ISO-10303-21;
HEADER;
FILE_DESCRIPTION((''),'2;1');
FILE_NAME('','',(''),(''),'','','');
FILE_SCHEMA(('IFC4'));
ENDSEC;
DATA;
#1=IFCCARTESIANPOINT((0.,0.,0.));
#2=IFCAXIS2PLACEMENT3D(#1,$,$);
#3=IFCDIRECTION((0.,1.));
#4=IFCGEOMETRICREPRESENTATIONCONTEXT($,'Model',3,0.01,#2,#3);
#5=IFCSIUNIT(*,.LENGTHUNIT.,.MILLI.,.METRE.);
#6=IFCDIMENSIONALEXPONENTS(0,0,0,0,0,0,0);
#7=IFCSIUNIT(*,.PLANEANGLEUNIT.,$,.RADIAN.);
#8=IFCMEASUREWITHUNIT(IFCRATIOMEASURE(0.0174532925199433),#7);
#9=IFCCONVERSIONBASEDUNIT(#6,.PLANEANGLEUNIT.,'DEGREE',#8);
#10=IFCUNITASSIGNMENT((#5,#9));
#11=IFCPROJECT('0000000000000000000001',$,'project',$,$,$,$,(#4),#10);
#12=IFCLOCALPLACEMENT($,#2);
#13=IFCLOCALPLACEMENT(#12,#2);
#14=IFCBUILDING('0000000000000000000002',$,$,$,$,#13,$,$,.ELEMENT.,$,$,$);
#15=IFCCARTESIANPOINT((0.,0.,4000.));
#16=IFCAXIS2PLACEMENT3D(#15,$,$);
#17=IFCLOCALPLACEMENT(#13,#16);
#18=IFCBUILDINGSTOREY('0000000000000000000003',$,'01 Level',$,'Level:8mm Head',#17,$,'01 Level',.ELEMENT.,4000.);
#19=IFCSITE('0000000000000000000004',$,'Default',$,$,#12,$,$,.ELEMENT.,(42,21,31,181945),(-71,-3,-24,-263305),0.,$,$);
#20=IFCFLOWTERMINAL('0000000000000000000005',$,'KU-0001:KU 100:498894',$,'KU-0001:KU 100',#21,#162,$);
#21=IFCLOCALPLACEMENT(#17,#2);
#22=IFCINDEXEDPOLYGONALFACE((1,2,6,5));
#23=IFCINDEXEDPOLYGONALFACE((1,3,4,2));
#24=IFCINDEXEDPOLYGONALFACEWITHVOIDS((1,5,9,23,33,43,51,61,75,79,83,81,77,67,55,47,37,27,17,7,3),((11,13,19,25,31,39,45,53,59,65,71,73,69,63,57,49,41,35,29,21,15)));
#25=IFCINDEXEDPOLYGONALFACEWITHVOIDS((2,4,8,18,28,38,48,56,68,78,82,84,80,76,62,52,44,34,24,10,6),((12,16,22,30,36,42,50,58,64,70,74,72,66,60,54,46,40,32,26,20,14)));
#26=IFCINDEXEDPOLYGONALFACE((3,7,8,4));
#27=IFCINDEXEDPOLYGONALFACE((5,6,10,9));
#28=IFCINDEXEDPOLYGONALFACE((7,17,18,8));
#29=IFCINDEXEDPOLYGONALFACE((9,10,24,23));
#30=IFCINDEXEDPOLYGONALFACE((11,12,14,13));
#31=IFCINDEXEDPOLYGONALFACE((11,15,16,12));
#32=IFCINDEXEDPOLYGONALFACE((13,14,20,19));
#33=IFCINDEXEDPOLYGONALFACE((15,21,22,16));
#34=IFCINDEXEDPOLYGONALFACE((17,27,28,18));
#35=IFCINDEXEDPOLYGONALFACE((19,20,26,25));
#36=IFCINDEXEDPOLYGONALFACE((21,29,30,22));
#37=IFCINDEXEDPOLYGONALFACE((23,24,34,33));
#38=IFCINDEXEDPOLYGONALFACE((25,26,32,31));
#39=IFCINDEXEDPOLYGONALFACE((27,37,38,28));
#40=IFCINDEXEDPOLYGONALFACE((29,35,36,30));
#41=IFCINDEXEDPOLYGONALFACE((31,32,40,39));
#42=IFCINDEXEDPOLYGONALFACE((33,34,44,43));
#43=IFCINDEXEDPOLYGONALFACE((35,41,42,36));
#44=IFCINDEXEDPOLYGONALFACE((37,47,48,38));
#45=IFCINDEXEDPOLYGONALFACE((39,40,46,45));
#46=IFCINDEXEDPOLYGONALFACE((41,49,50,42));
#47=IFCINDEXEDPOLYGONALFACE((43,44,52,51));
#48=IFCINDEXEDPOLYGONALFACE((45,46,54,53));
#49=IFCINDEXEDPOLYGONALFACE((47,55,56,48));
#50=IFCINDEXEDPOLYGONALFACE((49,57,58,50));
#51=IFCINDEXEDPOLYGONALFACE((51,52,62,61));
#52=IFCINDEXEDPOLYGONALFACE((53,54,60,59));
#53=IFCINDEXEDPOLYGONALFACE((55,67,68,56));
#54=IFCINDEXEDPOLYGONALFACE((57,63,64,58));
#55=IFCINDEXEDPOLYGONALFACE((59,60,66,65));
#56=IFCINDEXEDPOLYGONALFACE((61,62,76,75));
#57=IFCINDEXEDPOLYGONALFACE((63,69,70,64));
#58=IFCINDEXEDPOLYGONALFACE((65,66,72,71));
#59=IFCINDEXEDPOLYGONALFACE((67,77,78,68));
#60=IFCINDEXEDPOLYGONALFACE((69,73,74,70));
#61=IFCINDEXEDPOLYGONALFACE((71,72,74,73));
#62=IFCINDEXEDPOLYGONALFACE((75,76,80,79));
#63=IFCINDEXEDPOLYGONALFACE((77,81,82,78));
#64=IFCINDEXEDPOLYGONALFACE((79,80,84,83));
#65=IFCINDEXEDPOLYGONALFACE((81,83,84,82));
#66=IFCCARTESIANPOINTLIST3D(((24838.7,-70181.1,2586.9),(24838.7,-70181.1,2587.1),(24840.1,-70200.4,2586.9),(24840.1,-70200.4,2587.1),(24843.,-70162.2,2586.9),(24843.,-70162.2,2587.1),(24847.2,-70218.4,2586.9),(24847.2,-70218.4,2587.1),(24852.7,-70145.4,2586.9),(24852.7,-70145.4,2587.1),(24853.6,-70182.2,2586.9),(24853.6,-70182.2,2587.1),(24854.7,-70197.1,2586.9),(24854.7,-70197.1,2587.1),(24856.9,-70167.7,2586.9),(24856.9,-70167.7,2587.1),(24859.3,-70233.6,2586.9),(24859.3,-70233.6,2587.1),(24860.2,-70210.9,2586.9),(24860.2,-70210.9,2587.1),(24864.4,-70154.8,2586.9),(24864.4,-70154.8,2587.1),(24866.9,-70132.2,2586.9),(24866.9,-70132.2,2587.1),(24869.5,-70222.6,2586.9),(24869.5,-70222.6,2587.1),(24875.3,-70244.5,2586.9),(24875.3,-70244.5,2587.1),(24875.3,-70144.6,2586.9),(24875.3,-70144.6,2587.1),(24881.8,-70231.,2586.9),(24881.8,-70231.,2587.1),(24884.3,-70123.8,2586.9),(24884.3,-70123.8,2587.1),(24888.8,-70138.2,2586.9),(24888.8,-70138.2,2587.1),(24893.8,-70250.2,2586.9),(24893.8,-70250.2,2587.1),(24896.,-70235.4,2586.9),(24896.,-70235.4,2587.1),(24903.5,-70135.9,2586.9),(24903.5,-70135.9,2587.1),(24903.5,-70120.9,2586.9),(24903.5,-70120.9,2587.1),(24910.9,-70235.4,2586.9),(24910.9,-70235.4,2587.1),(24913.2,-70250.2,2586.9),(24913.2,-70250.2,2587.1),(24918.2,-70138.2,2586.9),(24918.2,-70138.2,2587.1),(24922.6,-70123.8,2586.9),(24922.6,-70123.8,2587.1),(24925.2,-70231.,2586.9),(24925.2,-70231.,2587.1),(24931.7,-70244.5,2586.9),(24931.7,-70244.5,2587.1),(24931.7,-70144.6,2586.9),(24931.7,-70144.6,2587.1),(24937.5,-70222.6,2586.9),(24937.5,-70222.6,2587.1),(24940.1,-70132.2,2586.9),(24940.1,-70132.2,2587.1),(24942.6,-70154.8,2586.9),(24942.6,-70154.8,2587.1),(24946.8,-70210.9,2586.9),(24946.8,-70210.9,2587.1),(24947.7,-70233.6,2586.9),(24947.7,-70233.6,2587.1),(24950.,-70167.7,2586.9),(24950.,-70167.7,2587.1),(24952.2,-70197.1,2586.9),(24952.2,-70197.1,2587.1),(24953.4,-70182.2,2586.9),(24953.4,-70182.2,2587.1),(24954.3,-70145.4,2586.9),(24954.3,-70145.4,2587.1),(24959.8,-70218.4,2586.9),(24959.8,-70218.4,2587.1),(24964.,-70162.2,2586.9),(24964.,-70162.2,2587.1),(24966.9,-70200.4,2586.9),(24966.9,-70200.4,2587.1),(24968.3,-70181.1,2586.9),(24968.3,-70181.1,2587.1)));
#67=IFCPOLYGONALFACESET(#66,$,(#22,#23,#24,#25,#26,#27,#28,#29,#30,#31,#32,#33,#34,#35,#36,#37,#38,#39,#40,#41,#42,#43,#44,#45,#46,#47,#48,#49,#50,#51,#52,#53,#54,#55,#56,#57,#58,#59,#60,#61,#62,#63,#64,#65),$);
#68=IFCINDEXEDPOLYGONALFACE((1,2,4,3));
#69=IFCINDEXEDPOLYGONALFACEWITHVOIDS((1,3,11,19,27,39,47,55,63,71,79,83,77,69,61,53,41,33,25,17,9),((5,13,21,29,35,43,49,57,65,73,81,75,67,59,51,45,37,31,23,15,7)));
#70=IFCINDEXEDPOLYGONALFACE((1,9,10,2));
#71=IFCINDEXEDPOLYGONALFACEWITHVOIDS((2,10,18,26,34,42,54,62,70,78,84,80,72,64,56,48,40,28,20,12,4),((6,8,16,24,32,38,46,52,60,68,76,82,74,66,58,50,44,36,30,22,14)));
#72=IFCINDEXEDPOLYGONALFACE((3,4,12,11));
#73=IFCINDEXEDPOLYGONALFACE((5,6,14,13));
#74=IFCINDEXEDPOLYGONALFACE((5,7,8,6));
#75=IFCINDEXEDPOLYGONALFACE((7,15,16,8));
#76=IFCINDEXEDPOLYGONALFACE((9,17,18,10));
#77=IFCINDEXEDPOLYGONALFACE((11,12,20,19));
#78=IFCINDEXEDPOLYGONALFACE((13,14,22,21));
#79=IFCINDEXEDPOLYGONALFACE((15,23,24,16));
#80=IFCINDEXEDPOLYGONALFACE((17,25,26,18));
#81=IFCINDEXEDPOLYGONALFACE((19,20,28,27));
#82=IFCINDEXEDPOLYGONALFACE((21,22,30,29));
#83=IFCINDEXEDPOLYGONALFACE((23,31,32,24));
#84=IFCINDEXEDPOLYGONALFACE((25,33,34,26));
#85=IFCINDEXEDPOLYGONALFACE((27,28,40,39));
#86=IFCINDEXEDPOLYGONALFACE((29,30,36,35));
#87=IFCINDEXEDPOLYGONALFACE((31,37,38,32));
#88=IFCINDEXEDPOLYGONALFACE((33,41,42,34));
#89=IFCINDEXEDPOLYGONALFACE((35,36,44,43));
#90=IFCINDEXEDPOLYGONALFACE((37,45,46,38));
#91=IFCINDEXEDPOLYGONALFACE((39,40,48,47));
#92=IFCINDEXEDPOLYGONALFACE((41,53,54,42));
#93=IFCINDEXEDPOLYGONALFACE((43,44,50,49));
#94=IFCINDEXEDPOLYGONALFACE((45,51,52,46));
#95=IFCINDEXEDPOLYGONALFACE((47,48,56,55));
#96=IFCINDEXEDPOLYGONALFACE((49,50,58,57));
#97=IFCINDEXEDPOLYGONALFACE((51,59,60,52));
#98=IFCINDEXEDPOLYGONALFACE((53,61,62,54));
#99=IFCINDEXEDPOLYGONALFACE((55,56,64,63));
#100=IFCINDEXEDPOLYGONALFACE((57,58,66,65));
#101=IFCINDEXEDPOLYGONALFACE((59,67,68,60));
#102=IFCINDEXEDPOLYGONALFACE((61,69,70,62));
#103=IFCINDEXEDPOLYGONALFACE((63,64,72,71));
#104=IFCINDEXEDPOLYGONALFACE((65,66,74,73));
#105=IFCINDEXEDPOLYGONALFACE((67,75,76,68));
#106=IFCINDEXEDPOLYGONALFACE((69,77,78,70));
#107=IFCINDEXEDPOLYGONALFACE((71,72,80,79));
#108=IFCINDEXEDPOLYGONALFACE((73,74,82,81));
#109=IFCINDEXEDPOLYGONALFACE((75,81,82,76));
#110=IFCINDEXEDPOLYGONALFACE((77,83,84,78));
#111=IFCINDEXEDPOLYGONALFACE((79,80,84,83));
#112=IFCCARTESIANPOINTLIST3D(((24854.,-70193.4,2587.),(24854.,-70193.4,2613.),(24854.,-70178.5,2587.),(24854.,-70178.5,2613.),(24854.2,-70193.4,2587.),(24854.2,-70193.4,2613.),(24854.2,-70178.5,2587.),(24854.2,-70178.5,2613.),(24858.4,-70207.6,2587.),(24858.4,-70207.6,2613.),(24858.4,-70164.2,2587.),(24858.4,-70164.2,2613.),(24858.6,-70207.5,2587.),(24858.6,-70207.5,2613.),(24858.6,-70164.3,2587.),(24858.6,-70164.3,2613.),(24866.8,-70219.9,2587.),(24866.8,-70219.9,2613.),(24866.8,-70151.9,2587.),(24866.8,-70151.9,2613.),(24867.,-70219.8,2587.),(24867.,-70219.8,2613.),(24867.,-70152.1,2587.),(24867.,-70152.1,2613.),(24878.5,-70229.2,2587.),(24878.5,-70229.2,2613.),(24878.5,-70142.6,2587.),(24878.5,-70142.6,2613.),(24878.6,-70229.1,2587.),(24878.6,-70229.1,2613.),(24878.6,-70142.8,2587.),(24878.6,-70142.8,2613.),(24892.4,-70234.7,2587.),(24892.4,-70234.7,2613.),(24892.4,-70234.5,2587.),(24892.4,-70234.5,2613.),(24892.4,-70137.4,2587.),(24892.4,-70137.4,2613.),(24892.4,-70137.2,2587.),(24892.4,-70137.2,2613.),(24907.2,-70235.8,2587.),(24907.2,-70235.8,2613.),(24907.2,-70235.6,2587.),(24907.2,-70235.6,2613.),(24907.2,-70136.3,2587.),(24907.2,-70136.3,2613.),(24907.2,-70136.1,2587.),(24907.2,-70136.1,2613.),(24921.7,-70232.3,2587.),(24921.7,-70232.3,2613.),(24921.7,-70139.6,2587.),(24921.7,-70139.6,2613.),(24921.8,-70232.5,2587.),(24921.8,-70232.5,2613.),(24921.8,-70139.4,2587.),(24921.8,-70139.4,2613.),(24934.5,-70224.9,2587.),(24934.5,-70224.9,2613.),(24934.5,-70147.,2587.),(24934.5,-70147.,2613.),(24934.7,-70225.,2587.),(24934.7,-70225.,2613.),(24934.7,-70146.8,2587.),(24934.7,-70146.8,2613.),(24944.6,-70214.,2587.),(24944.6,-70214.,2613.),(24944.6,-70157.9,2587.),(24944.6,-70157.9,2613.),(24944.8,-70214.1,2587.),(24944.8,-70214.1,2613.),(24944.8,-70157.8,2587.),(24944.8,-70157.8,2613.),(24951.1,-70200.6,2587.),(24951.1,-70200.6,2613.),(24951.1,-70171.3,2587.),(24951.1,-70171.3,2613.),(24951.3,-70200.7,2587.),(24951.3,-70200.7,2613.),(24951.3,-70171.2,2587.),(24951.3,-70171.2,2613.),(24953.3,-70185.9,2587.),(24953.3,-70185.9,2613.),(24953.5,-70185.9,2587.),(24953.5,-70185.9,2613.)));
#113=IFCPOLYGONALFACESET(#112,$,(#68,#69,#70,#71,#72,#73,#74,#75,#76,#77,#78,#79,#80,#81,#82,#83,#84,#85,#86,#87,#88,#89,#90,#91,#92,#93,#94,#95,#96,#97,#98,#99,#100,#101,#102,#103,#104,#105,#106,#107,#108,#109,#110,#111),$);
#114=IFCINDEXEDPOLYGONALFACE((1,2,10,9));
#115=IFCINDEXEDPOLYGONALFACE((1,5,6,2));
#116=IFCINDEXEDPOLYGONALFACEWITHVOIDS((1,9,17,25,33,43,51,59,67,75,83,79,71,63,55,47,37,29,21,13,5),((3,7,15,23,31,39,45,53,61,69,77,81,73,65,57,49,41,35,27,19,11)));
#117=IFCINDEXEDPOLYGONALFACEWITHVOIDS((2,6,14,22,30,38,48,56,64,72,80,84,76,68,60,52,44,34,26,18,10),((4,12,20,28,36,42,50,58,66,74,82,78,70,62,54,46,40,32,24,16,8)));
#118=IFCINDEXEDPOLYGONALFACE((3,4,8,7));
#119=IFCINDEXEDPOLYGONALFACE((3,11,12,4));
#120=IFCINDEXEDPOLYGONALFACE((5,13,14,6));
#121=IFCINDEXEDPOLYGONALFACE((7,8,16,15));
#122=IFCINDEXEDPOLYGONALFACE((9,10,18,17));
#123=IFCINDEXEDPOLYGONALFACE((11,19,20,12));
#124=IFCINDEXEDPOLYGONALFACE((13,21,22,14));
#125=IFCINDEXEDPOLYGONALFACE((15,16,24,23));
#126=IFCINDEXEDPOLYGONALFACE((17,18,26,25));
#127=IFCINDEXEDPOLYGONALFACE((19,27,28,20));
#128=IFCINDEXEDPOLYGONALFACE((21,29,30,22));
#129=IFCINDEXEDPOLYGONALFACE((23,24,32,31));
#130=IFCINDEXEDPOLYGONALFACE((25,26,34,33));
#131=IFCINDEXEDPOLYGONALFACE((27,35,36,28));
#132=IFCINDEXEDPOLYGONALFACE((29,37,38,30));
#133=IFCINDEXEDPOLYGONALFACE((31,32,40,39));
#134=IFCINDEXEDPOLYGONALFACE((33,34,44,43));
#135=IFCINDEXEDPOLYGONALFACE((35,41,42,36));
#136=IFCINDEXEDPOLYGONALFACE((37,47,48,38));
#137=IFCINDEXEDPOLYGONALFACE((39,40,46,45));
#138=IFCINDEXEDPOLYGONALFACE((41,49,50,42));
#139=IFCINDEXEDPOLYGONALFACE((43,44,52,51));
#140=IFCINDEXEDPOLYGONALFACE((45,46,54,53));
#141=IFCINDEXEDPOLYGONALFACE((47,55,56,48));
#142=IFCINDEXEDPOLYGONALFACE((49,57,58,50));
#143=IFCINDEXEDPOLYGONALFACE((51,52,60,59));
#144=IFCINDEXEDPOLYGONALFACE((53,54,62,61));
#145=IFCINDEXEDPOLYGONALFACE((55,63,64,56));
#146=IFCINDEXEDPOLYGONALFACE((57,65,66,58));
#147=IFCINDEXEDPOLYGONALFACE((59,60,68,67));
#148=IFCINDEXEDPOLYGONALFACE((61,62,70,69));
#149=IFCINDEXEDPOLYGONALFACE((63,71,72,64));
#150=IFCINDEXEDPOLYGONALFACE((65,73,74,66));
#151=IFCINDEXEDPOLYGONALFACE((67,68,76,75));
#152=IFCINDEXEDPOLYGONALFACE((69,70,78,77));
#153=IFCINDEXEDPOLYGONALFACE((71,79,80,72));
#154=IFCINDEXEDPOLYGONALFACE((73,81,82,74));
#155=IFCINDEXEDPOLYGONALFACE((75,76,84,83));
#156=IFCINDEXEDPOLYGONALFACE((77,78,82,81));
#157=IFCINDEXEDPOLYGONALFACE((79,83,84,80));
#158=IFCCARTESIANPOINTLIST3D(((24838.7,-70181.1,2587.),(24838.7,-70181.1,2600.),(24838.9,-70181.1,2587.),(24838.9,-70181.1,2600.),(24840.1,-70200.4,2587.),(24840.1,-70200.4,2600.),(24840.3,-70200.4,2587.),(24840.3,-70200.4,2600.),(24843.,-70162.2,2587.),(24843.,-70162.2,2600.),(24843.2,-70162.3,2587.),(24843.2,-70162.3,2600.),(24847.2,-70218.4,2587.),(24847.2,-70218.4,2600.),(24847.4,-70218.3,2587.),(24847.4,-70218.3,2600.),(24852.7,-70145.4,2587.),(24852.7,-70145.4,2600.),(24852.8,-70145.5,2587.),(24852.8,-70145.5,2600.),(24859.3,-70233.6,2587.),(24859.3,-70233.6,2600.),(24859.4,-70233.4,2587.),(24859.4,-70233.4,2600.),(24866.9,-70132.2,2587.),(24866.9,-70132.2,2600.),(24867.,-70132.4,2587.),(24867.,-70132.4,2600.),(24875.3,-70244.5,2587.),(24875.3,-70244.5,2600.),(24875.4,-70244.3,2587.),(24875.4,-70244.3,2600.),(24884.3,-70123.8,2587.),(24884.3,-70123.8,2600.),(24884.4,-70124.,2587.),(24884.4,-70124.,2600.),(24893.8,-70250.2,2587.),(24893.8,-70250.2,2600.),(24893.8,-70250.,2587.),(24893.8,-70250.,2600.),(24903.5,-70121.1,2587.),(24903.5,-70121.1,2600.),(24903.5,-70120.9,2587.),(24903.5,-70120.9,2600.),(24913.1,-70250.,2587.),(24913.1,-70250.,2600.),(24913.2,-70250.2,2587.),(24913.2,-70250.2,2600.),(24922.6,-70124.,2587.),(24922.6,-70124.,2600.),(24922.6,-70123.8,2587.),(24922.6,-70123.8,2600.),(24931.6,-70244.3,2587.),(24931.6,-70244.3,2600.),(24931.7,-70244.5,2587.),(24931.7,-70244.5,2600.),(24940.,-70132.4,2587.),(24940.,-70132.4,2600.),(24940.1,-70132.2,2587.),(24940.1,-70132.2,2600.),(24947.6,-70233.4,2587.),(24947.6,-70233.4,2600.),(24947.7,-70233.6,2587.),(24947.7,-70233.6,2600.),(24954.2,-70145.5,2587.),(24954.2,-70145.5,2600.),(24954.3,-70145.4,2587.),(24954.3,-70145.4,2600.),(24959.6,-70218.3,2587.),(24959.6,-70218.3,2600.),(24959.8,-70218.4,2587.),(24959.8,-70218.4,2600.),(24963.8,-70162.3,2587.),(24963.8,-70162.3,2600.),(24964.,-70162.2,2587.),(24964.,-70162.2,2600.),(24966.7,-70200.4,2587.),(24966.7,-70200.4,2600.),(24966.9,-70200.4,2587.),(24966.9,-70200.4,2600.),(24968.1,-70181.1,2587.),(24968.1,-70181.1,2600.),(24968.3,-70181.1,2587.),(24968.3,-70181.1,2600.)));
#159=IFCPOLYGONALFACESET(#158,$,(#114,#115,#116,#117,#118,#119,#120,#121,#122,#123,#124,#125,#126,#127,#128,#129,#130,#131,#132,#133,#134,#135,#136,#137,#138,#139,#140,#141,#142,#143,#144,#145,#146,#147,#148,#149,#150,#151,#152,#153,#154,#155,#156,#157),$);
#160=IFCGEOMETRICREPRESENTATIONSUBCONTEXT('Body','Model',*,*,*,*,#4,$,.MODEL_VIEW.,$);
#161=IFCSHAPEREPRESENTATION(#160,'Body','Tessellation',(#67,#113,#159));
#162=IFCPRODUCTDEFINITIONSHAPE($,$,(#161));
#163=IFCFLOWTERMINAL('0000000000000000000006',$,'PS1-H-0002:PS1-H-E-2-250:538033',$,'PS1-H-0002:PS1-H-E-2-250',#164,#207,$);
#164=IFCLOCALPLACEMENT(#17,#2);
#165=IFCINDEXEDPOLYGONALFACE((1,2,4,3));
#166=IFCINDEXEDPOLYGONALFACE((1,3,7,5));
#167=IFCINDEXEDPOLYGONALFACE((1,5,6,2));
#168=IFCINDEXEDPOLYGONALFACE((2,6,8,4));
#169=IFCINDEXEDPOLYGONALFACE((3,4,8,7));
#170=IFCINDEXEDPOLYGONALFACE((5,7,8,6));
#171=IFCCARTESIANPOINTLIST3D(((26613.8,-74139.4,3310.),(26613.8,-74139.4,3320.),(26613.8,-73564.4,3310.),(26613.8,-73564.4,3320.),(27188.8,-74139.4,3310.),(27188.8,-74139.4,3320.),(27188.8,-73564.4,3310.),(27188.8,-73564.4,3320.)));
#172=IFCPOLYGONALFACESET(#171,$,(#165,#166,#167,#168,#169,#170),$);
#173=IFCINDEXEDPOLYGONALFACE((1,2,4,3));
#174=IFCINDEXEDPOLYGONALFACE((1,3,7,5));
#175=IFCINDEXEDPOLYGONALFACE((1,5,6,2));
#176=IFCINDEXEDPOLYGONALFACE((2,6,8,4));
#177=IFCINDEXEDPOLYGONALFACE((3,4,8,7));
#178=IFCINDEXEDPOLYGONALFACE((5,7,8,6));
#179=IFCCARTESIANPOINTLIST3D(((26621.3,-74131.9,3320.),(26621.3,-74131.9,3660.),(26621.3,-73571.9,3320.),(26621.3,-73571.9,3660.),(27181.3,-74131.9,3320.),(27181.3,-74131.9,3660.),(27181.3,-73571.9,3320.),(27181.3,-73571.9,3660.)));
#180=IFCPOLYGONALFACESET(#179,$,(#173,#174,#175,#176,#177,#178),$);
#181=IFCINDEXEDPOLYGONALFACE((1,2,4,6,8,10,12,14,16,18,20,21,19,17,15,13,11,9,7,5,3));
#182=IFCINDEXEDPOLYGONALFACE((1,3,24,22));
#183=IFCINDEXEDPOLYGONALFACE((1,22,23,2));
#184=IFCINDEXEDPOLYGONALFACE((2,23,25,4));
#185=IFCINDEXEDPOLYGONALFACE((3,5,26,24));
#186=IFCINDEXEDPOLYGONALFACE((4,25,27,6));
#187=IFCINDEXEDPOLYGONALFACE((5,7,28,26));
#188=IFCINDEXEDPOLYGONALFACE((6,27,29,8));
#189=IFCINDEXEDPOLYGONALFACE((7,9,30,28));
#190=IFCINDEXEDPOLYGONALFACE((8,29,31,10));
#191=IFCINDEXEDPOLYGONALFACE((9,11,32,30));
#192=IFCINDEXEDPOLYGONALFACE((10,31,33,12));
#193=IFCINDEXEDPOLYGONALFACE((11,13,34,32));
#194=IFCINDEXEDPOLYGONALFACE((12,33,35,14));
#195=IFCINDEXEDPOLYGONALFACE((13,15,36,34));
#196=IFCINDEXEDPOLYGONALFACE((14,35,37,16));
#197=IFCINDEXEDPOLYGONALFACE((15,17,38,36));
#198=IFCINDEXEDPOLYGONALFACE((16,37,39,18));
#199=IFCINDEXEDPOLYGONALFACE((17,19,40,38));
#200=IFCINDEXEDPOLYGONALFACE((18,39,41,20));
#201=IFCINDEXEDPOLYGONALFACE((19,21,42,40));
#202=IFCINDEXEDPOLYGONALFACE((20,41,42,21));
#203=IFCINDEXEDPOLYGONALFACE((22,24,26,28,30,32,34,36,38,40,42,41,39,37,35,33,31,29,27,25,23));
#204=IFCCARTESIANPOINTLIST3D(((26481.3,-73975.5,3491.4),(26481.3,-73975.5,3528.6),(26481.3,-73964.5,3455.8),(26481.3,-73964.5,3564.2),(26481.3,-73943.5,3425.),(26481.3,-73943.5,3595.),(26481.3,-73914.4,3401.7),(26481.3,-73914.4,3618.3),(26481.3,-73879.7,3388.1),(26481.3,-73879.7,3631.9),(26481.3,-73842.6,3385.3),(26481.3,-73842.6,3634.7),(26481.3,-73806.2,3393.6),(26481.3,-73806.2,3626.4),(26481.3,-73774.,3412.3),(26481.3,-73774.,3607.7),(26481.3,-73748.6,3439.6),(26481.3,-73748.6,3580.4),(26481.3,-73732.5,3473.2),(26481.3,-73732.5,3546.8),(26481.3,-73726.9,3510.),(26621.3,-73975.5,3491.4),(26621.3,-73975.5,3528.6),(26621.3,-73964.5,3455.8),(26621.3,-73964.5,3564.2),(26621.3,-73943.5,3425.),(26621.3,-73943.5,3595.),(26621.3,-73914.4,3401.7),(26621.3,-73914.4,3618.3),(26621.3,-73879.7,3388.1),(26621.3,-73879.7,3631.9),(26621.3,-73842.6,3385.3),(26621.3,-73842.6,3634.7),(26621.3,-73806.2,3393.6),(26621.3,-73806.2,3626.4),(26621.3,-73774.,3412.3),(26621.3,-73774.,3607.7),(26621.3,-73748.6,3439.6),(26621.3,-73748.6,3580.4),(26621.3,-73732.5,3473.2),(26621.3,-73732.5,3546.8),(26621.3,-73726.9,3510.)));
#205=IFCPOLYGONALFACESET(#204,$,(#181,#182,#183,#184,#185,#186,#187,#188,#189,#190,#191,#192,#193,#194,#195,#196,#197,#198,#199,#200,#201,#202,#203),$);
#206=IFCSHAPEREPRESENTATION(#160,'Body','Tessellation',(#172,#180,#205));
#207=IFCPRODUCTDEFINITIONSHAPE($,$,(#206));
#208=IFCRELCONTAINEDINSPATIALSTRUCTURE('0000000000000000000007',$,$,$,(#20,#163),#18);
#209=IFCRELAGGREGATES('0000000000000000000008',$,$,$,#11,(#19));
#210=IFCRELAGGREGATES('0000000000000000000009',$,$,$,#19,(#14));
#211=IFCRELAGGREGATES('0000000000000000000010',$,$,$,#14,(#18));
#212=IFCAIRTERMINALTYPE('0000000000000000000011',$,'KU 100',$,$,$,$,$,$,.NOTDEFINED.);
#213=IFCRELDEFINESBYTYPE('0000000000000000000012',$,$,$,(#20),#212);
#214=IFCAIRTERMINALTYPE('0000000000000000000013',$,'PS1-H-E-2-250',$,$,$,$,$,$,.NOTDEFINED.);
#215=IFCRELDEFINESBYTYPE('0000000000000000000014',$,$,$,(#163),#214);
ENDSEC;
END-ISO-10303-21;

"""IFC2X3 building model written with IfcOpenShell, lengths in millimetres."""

from ifc_helpers import new_model, entity, si_unit, converted_unit, direction, frame, frame_2d, origin, origin_2d_with_axis, place, context, subcontext, project, spatial, rectangle, circle, hollow_circle, extrude, source, transform, mapped, type_object, type_shapes, element, save


model = new_model("IFC2X3")

# Units and contexts
model_context = context("Model", 3, precision=0.01, world=origin(), true_north=direction((0.0, 1.0)))
body_context = subcontext(model_context, "Body", "Model", "MODEL_VIEW")
ifc_project = project(units=[si_unit("LENGTHUNIT", "METRE", prefix="MILLI"), converted_unit("PLANEANGLEUNIT", "DEGREE", entity("IfcRatioMeasure", 0.0174532925199433), si_unit("PLANEANGLEUNIT", "RADIAN"), dimensions=[0, 0, 0, 0, 0, 0, 0])], contexts=[model_context])

# Site, building, storey
site_placement = place(None, origin())
site = spatial("IfcSite", under=ifc_project, at=site_placement, Name="Default", CompositionType="ELEMENT", RefLatitude=(42, 21, 31, 181945), RefLongitude=(-71, -3, -24, -263305), RefElevation=0.0)
building_placement = place(site_placement, origin())
building = spatial("IfcBuilding", under=site, at=building_placement, CompositionType="ELEMENT")
storey_placement = place(building_placement, frame((0.0, 0.0, 4000.0)))
storey = spatial("IfcBuildingStorey", under=building, at=storey_placement, Name="01 Level", ObjectType="Level:8mm Head", LongName="01 Level", CompositionType="ELEMENT", Elevation=4000.0)

# Flow terminals
air_terminal_type_1 = type_object("IfcAirTerminalType", Name="KU 100", PredefinedType="NOTDEFINED")
shared_shape_1 = source(origin(), body_context, "Body", "SweptSolid", [
    extrude(hollow_circle(Radius=65.0, WallThickness=15.0, at=frame_2d((0.0, 0.0), x_axis=(1.0, 0.0))), frame((12.9, 0.0, 0.0), z_axis=(1.0, 0.0, 0.0), x_axis=(0.0, 1.0, 0.0)), (0.0, 0.0, 1.0), 0.2),
    extrude(hollow_circle(Radius=50.0, WallThickness=0.2, at=frame_2d((0.0, 0.0), x_axis=(1.0, 0.0))), frame((-13.0, 0.0, 0.0), z_axis=(1.0, 0.0, 0.0), x_axis=(0.0, 0.0, 1.0)), (0.0, 0.0, 1.0), 26.0),
    extrude(hollow_circle(Radius=65.0, WallThickness=0.2, at=frame_2d((0.0, 0.0), x_axis=(1.0, 0.0))), frame((0.0, 0.0, 0.0), z_axis=(1.0, 0.0, 0.0), x_axis=(0.0, 1.0, 0.0)), (0.0, 0.0, 1.0), 13.0),
])
type_shapes(air_terminal_type_1, [shared_shape_1])
flow_terminal_1_placement = place(storey_placement, frame((24903.5, -70185.9, 2600.0), z_axis=(1.0, 0.0, 0.0), x_axis=(0.0, 0.0, -1.0)))
element("IfcFlowTerminal", 1, at=flow_terminal_1_placement, inside=storey, type_object=air_terminal_type_1, Name="KU-0001:KU 100:498894", ObjectType="KU-0001:KU 100", context=body_context, shape_type="MappedRepresentation", body=[
    mapped(shared_shape_1, transform((0.0, 0.0, 0.0), scale=1.0)),
])
air_terminal_type_2 = type_object("IfcAirTerminalType", Name="PS1-H-E-2-250", PredefinedType="NOTDEFINED")
shared_shape_2 = source(origin(), body_context, "Body", "SweptSolid", [
    extrude(rectangle(XDim=575.0, YDim=575.0, at=origin_2d_with_axis()), frame((0.0, 0.0, -10.0), z_axis=(0.0, 0.0, 1.0), x_axis=(-1.0, 0.0, 0.0)), (0.0, 0.0, 1.0), 10.0),
    extrude(rectangle(XDim=560.0, YDim=560.0, at=origin_2d_with_axis()), frame((0.0, 0.0, 0.0), z_axis=(0.0, 0.0, 1.0), x_axis=(-1.0, 0.0, 0.0)), (0.0, 0.0, 1.0), 340.0),
    extrude(circle(Radius=125.0, at=frame_2d((0.0, 0.0), x_axis=(1.0, 0.0))), frame((-420.0, 0.0, 190.0), z_axis=(1.0, 0.0, 0.0), x_axis=(0.0, 1.0, 0.0)), (0.0, 0.0, 1.0), 140.0),
])
type_shapes(air_terminal_type_2, [shared_shape_2])
flow_terminal_2_placement = place(storey_placement, frame((26901.3, -73851.9, 3320.0)))
element("IfcFlowTerminal", 2, at=flow_terminal_2_placement, inside=storey, type_object=air_terminal_type_2, Name="PS1-H-0002:PS1-H-E-2-250:538033", ObjectType="PS1-H-0002:PS1-H-E-2-250", context=body_context, shape_type="MappedRepresentation", body=[
    mapped(shared_shape_2, transform((0.0, 0.0, 0.0), scale=1.0)),
])

save(model, "model.ifc")
